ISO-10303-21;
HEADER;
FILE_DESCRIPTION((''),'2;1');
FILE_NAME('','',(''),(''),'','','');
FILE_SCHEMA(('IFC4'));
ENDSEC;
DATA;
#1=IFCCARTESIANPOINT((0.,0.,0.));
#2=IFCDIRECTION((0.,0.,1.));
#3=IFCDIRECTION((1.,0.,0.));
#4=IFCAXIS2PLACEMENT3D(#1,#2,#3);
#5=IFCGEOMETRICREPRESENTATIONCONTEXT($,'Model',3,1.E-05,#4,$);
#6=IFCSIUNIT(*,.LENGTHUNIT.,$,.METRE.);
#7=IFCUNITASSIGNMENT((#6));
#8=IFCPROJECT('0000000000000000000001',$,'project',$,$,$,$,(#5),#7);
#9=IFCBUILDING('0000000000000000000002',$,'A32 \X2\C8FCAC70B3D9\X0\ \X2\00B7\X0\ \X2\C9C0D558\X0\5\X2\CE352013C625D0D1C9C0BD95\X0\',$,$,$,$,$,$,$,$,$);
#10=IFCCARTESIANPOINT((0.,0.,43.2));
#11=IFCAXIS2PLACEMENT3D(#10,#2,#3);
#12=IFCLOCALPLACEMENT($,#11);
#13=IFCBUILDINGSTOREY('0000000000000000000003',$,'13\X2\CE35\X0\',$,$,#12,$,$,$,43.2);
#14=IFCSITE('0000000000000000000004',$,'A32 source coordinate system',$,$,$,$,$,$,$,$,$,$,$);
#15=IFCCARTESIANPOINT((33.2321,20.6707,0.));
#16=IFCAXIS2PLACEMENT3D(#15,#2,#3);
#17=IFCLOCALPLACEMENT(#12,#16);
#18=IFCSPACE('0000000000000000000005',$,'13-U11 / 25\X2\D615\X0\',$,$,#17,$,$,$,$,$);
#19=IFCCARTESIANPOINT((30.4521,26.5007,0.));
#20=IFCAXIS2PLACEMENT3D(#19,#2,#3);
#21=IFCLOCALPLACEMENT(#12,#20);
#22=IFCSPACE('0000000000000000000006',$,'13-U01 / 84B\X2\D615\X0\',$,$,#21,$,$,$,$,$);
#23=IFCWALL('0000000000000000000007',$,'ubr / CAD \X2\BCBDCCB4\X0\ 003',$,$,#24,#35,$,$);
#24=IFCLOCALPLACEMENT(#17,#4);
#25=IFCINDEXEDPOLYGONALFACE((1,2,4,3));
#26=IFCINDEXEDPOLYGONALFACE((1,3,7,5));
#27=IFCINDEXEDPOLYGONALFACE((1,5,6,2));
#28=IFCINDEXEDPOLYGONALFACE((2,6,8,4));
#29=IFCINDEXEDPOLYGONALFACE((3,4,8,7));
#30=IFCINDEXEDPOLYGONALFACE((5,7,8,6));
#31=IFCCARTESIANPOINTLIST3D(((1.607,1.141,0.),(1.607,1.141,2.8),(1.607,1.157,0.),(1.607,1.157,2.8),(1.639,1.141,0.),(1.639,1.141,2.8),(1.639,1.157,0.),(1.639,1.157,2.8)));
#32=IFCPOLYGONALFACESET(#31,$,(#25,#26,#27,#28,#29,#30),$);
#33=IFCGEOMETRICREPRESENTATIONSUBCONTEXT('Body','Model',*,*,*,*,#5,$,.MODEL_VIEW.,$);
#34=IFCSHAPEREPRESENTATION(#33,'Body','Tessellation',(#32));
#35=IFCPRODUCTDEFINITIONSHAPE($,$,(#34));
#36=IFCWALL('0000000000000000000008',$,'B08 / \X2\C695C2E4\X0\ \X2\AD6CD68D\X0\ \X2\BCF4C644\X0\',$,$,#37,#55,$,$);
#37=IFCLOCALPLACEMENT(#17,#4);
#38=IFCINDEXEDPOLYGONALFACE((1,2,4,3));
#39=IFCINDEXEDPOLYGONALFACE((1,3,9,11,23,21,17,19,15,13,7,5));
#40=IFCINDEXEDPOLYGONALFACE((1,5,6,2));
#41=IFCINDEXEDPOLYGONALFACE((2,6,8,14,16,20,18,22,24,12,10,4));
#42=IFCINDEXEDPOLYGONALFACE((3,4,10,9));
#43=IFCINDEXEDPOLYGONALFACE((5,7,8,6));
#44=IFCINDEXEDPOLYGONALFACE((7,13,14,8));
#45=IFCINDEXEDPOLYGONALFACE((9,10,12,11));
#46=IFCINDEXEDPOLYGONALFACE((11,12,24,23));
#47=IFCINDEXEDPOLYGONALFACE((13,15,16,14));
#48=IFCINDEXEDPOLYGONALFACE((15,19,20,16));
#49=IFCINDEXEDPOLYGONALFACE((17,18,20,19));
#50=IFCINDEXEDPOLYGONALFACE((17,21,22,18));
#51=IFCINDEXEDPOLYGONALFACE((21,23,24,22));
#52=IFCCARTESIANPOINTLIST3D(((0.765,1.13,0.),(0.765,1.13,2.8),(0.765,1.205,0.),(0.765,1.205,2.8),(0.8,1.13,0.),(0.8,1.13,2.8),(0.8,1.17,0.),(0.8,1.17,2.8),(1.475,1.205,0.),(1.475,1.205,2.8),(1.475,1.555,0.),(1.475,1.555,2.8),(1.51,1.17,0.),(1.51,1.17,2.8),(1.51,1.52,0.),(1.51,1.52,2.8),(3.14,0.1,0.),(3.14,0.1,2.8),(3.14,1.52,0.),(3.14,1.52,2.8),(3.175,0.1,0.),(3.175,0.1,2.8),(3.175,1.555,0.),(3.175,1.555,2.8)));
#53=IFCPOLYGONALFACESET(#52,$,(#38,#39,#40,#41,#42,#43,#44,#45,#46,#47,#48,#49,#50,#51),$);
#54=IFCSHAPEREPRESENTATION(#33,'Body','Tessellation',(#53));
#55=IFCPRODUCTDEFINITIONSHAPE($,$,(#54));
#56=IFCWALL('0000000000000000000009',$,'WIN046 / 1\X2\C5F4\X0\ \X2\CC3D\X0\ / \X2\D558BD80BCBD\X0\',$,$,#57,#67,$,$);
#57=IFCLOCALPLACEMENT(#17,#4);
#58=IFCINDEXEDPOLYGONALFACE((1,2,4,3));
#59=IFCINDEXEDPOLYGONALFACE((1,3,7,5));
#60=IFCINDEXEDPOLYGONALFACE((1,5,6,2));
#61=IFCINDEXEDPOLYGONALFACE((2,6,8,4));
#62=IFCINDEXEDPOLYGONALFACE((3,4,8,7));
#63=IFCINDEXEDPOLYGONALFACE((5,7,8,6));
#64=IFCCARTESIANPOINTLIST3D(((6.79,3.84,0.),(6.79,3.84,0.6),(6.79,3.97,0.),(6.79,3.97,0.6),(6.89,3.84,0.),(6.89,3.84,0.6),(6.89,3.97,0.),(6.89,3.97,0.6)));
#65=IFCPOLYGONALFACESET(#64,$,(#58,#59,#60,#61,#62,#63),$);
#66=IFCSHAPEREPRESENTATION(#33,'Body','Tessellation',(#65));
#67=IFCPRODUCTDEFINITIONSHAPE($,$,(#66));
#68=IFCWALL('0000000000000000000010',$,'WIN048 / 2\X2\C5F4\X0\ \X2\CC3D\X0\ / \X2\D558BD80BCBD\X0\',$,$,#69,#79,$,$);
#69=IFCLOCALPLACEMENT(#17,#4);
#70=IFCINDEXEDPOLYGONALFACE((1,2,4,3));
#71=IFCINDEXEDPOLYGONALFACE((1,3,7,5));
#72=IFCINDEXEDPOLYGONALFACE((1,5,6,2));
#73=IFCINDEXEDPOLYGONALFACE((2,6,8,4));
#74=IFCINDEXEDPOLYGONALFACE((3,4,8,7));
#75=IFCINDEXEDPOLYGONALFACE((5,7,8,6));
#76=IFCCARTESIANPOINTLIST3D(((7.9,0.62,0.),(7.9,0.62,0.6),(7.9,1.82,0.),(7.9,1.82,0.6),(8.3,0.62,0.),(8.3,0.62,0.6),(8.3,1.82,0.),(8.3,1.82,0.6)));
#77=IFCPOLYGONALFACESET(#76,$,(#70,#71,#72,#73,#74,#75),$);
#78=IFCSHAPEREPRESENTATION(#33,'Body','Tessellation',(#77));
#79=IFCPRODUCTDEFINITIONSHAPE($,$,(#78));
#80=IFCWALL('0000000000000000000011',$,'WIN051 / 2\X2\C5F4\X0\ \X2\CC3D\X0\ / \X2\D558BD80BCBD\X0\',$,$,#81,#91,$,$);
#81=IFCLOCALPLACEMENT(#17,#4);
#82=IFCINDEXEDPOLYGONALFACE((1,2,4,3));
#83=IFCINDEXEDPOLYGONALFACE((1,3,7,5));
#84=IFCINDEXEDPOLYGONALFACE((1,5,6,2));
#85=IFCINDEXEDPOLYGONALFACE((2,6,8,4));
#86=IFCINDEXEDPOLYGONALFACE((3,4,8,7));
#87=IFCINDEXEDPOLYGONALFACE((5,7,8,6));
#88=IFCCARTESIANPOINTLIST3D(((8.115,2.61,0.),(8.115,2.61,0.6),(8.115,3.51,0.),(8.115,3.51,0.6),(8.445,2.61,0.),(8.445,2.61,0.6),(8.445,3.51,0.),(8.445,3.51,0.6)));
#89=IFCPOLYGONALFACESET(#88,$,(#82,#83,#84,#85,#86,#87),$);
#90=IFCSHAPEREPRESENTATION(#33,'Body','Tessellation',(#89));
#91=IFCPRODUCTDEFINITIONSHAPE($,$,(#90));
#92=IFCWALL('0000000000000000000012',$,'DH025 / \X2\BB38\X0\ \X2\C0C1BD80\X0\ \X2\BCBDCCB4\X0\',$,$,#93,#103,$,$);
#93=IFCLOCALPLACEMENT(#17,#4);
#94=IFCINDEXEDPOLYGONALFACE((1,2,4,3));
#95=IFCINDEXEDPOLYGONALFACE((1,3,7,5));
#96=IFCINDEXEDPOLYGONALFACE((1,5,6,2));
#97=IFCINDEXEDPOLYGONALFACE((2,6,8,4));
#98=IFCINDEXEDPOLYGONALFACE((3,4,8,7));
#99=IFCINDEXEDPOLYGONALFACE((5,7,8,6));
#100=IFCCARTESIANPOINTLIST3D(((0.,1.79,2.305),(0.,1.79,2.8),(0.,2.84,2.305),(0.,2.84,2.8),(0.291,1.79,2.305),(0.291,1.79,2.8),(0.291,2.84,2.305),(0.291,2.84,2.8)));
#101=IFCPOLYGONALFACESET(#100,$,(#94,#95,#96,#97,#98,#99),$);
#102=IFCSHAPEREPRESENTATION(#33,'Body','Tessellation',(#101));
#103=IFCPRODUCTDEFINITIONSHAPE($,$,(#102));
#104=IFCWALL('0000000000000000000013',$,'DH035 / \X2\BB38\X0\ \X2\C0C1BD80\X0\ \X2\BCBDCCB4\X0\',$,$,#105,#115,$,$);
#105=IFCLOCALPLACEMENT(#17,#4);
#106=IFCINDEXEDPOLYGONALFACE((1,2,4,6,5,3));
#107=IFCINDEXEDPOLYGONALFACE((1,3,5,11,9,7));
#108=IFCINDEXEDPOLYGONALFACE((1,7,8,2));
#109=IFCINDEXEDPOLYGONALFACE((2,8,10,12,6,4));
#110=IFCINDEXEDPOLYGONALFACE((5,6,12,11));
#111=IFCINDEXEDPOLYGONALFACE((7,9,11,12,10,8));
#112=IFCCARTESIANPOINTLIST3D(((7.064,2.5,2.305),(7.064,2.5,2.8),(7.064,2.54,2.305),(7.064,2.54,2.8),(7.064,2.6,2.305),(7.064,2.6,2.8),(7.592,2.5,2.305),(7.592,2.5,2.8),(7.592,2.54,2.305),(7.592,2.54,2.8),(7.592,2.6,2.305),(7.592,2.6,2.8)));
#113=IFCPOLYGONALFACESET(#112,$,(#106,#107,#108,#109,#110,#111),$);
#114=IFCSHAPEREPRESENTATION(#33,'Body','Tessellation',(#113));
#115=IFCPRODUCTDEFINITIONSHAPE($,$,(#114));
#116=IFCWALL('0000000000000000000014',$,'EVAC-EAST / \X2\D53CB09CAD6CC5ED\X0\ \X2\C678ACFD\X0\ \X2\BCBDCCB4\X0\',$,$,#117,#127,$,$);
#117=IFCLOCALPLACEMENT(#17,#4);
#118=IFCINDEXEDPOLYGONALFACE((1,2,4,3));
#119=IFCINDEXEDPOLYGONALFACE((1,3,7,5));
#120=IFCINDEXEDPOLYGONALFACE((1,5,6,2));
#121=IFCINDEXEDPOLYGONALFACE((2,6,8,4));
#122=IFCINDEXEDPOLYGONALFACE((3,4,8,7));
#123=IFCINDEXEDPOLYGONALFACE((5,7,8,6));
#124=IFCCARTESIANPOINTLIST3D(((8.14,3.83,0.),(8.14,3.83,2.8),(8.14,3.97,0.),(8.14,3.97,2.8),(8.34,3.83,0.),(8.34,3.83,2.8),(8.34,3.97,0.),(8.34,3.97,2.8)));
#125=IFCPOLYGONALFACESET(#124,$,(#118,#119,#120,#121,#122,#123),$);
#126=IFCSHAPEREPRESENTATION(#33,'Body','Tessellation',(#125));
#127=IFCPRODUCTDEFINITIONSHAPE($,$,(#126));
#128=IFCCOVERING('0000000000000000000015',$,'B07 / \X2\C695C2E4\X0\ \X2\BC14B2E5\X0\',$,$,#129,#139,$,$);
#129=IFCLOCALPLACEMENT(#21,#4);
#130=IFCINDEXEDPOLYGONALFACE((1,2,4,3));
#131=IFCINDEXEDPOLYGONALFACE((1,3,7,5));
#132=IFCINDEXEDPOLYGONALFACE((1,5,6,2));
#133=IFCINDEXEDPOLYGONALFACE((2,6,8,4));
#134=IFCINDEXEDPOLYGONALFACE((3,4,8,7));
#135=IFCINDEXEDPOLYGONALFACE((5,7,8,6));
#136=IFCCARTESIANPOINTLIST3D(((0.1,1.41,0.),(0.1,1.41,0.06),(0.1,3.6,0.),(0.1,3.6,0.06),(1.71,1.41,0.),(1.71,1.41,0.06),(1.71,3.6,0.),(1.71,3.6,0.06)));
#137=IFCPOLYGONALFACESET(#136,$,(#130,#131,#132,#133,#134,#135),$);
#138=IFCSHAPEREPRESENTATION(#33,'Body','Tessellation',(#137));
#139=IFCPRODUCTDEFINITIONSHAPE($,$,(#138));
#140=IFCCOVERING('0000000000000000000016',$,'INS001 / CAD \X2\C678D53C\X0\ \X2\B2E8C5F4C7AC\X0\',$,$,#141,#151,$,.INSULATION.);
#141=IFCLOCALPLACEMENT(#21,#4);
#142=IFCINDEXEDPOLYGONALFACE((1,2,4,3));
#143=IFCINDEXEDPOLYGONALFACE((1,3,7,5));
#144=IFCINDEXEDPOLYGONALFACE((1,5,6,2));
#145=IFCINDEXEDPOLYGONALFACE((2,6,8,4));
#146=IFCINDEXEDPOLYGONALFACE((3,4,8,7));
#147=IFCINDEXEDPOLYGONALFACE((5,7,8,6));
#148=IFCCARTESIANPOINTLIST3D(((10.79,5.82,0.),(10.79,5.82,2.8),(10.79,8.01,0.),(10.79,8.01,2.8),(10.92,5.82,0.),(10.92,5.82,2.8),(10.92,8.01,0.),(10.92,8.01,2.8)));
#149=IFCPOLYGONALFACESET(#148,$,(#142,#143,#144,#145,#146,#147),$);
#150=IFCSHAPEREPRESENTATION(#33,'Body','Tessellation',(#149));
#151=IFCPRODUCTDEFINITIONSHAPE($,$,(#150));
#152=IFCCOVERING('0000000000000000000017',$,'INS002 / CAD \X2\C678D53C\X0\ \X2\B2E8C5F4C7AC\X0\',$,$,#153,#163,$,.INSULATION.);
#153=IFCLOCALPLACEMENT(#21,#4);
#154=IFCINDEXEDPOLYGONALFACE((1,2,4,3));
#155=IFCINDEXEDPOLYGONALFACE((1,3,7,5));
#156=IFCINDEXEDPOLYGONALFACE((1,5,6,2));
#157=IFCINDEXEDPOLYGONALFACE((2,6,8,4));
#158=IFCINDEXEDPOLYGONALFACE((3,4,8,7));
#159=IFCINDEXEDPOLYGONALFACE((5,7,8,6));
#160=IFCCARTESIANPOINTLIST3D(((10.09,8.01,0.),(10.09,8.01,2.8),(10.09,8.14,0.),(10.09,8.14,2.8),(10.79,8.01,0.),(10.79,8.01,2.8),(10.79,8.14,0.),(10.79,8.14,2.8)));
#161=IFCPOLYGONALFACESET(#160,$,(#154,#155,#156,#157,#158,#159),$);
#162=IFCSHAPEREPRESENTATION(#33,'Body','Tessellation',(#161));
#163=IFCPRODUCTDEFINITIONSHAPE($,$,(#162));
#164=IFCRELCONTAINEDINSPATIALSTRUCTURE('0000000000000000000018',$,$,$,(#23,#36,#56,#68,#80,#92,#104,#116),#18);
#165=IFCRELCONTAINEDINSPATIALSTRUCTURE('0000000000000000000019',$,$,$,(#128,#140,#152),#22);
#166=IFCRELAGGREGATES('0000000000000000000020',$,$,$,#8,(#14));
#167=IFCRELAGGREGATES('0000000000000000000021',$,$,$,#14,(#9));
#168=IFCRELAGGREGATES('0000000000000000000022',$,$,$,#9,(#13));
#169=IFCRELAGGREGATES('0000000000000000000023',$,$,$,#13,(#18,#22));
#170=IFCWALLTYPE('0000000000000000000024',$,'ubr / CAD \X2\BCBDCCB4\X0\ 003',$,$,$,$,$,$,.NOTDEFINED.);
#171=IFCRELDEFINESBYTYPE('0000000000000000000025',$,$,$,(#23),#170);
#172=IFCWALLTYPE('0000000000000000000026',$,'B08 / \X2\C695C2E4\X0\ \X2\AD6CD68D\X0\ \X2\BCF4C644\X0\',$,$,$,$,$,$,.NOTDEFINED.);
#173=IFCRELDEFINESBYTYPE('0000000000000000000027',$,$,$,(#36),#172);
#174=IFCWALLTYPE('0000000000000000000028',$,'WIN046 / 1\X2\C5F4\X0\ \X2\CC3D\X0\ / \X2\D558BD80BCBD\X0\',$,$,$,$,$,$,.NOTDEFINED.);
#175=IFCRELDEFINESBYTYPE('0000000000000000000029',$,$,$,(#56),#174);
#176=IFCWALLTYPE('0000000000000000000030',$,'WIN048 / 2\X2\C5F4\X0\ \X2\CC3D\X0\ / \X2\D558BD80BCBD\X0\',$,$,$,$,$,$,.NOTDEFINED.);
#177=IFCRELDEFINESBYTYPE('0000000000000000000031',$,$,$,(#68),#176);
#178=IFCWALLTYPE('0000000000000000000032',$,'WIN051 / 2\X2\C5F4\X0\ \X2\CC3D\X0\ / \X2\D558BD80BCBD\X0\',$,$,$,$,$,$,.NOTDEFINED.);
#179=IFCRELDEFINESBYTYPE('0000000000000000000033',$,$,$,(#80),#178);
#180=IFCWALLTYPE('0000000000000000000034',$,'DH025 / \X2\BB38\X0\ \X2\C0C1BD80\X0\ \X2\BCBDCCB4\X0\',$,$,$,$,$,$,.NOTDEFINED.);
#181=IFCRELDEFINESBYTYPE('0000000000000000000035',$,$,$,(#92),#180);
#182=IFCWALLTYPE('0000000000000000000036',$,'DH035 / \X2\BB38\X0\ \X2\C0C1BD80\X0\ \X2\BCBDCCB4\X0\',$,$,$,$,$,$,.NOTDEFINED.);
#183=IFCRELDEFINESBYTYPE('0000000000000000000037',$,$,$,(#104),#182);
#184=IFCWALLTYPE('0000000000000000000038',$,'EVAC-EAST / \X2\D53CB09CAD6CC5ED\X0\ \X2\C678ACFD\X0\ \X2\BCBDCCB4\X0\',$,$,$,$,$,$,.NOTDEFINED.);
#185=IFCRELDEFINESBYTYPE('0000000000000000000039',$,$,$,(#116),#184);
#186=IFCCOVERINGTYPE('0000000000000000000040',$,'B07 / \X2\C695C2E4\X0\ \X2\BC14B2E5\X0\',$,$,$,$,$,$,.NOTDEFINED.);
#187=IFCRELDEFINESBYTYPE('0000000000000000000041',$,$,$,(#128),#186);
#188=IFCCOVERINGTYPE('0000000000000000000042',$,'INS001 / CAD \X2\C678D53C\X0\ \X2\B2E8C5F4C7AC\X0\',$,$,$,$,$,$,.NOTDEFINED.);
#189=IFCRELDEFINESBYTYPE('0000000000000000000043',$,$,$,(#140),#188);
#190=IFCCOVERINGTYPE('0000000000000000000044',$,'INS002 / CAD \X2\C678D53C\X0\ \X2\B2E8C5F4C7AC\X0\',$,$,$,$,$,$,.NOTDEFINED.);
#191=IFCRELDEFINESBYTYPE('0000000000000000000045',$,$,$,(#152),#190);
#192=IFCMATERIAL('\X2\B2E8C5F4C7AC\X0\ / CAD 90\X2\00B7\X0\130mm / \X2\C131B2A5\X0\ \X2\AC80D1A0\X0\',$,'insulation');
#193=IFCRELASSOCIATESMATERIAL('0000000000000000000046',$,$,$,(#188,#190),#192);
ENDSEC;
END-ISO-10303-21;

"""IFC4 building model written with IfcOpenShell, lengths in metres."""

from ifc_helpers import new_model, si_unit, frame, origin, origin_with_axes, place, context, subcontext, project, spatial, polyline, outline, extrude, source, transform, mapped, material, type_object, type_shapes, element, save


model = new_model("IFC4")

# Units and contexts
model_context = context("Model", 3, precision=1e-05, world=origin_with_axes())
body_context = subcontext(model_context, "Body", "Model", "MODEL_VIEW")
ifc_project = project(units=[si_unit("LENGTHUNIT", "METRE")], contexts=[model_context])

# Site, building, storey, space
site = spatial("IfcSite", under=ifc_project, Name="A32 source coordinate system")
building = spatial("IfcBuilding", under=site, Name="A32 주거동 · 지하5층–옥탑지붕")
storey_placement = place(None, frame((0.0, 0.0, 43.2), z_axis=(0.0, 0.0, 1.0), x_axis=(1.0, 0.0, 0.0)))
storey = spatial("IfcBuildingStorey", under=building, at=storey_placement, Name="13층", Elevation=43.2)
space_1_placement = place(storey_placement, frame((33.2321, 20.6707, 0.0), z_axis=(0.0, 0.0, 1.0), x_axis=(1.0, 0.0, 0.0)))
space_1 = spatial("IfcSpace", under=storey, at=space_1_placement, Name="13-U11 / 25형")

# Walls
wall_type_1 = type_object("IfcWallType", Name="ubr / CAD 벽체 003", PredefinedType="NOTDEFINED")
shared_shape_1 = source(origin(), body_context, "Body", "SweptSolid", [
    extrude(outline(polyline([(1.639, 1.157), (1.639, 1.141), (1.607, 1.141), (1.607, 1.157), (1.639, 1.157)])), origin(), (0.0, 0.0, 1.0), 2.8),
])
type_shapes(wall_type_1, [shared_shape_1])
wall_1_placement = place(space_1_placement, origin_with_axes())
element("IfcWall", 1, at=wall_1_placement, inside=space_1, type_object=wall_type_1, Name="ubr / CAD 벽체 003", context=body_context, shape_type="MappedRepresentation", body=[
    mapped(shared_shape_1, transform((0.0, 0.0, 0.0), scale=1.0)),
])
wall_type_2 = type_object("IfcWallType", Name="B08 / 욕실 구획 보완", PredefinedType="NOTDEFINED")
shared_shape_2 = source(origin(), body_context, "Body", "SweptSolid", [
    extrude(outline(polyline([(0.765, 1.205), (1.475, 1.205), (1.475, 1.555), (3.175, 1.555), (3.175, 0.1), (3.14, 0.1), (3.14, 1.52), (1.51, 1.52), (1.51, 1.17), (0.8, 1.17), (0.8, 1.13), (0.765, 1.13), (0.765, 1.205)])), origin(), (0.0, 0.0, 1.0), 2.8),
])
type_shapes(wall_type_2, [shared_shape_2])
wall_2_placement = place(space_1_placement, origin_with_axes())
element("IfcWall", 2, at=wall_2_placement, inside=space_1, type_object=wall_type_2, Name="B08 / 욕실 구획 보완", context=body_context, shape_type="MappedRepresentation", body=[
    mapped(shared_shape_2, transform((0.0, 0.0, 0.0), scale=1.0)),
])
wall_type_3 = type_object("IfcWallType", Name="WIN046 / 1열 창 / 하부벽", PredefinedType="NOTDEFINED")
shared_shape_3 = source(origin(), body_context, "Body", "SweptSolid", [
    extrude(outline(polyline([(6.89, 3.84), (6.79, 3.84), (6.79, 3.97), (6.89, 3.97), (6.89, 3.84)])), origin(), (0.0, 0.0, 1.0), 0.6),
])
type_shapes(wall_type_3, [shared_shape_3])
wall_3_placement = place(space_1_placement, origin_with_axes())
element("IfcWall", 3, at=wall_3_placement, inside=space_1, type_object=wall_type_3, Name="WIN046 / 1열 창 / 하부벽", context=body_context, shape_type="MappedRepresentation", body=[
    mapped(shared_shape_3, transform((0.0, 0.0, 0.0), scale=1.0)),
])
wall_type_4 = type_object("IfcWallType", Name="WIN048 / 2열 창 / 하부벽", PredefinedType="NOTDEFINED")
shared_shape_4 = source(origin(), body_context, "Body", "SweptSolid", [
    extrude(outline(polyline([(8.3, 0.62), (7.9, 0.62), (7.9, 1.82), (8.3, 1.82), (8.3, 0.62)])), origin(), (0.0, 0.0, 1.0), 0.6),
])
type_shapes(wall_type_4, [shared_shape_4])
wall_4_placement = place(space_1_placement, origin_with_axes())
element("IfcWall", 4, at=wall_4_placement, inside=space_1, type_object=wall_type_4, Name="WIN048 / 2열 창 / 하부벽", context=body_context, shape_type="MappedRepresentation", body=[
    mapped(shared_shape_4, transform((0.0, 0.0, 0.0), scale=1.0)),
])
wall_type_5 = type_object("IfcWallType", Name="WIN051 / 2열 창 / 하부벽", PredefinedType="NOTDEFINED")
shared_shape_5 = source(origin(), body_context, "Body", "SweptSolid", [
    extrude(outline(polyline([(8.445, 2.61), (8.115, 2.61), (8.115, 3.51), (8.445, 3.51), (8.445, 2.61)])), origin(), (0.0, 0.0, 1.0), 0.6),
])
type_shapes(wall_type_5, [shared_shape_5])
wall_5_placement = place(space_1_placement, origin_with_axes())
element("IfcWall", 5, at=wall_5_placement, inside=space_1, type_object=wall_type_5, Name="WIN051 / 2열 창 / 하부벽", context=body_context, shape_type="MappedRepresentation", body=[
    mapped(shared_shape_5, transform((0.0, 0.0, 0.0), scale=1.0)),
])
wall_type_6 = type_object("IfcWallType", Name="DH025 / 문 상부 벽체", PredefinedType="NOTDEFINED")
shared_shape_6 = source(origin(), body_context, "Body", "SweptSolid", [
    extrude(outline(polyline([(0.0, 1.79), (0.0, 2.84), (0.291, 2.84), (0.291, 1.79), (0.0, 1.79)])), frame((0.0, 0.0, 2.305)), (0.0, 0.0, 1.0), 0.495),
])
type_shapes(wall_type_6, [shared_shape_6])
wall_6_placement = place(space_1_placement, origin_with_axes())
element("IfcWall", 6, at=wall_6_placement, inside=space_1, type_object=wall_type_6, Name="DH025 / 문 상부 벽체", context=body_context, shape_type="MappedRepresentation", body=[
    mapped(shared_shape_6, transform((0.0, 0.0, 0.0), scale=1.0)),
])
wall_type_7 = type_object("IfcWallType", Name="DH035 / 문 상부 벽체", PredefinedType="NOTDEFINED")
shared_shape_7 = source(origin(), body_context, "Body", "SweptSolid", [
    extrude(outline(polyline([(7.592, 2.6), (7.592, 2.54), (7.592, 2.5), (7.064, 2.5), (7.064, 2.54), (7.064, 2.6), (7.592, 2.6)])), frame((0.0, 0.0, 2.305)), (0.0, 0.0, 1.0), 0.495),
])
type_shapes(wall_type_7, [shared_shape_7])
wall_7_placement = place(space_1_placement, origin_with_axes())
element("IfcWall", 7, at=wall_7_placement, inside=space_1, type_object=wall_type_7, Name="DH035 / 문 상부 벽체", context=body_context, shape_type="MappedRepresentation", body=[
    mapped(shared_shape_7, transform((0.0, 0.0, 0.0), scale=1.0)),
])
wall_type_8 = type_object("IfcWallType", Name="EVAC-EAST / 피난구역 외곽 벽체", PredefinedType="NOTDEFINED")
shared_shape_8 = source(origin(), body_context, "Body", "SweptSolid", [
    extrude(outline(polyline([(8.34, 3.83), (8.14, 3.83), (8.14, 3.97), (8.34, 3.97), (8.34, 3.83)])), origin(), (0.0, 0.0, 1.0), 2.8),
])
type_shapes(wall_type_8, [shared_shape_8])
wall_8_placement = place(space_1_placement, origin_with_axes())
element("IfcWall", 8, at=wall_8_placement, inside=space_1, type_object=wall_type_8, Name="EVAC-EAST / 피난구역 외곽 벽체", context=body_context, shape_type="MappedRepresentation", body=[
    mapped(shared_shape_8, transform((0.0, 0.0, 0.0), scale=1.0)),
])

# Shared definitions
space_2_placement = place(storey_placement, frame((30.4521, 26.5007, 0.0), z_axis=(0.0, 0.0, 1.0), x_axis=(1.0, 0.0, 0.0)))
space_2 = spatial("IfcSpace", under=storey, at=space_2_placement, Name="13-U01 / 84B형")

# Coverings
covering_type_1 = type_object("IfcCoveringType", Name="B07 / 욕실 바닥", PredefinedType="NOTDEFINED")
shared_shape_9 = source(origin(), body_context, "Body", "SweptSolid", [
    extrude(outline(polyline([(1.71, 1.41), (0.1, 1.41), (0.1, 3.6), (1.71, 3.6), (1.71, 1.41)])), origin(), (0.0, 0.0, 1.0), 0.06),
])
type_shapes(covering_type_1, [shared_shape_9])
covering_1_placement = place(space_2_placement, origin_with_axes())
element("IfcCovering", 9, at=covering_1_placement, inside=space_2, type_object=covering_type_1, Name="B07 / 욕실 바닥", context=body_context, shape_type="MappedRepresentation", body=[
    mapped(shared_shape_9, transform((0.0, 0.0, 0.0), scale=1.0)),
])
ifc_material = material(Name="단열재 / CAD 90·130mm / 성능 검토", Category="insulation")
covering_type_2 = type_object("IfcCoveringType", Name="INS001 / CAD 외피 단열재", PredefinedType="NOTDEFINED", material=ifc_material)
shared_shape_10 = source(origin(), body_context, "Body", "SweptSolid", [
    extrude(outline(polyline([(10.79, 5.82), (10.79, 8.01), (10.92, 8.01), (10.92, 5.82), (10.79, 5.82)])), origin(), (0.0, 0.0, 1.0), 2.8),
])
type_shapes(covering_type_2, [shared_shape_10])
covering_2_placement = place(space_2_placement, origin_with_axes())
element("IfcCovering", 10, at=covering_2_placement, inside=space_2, type_object=covering_type_2, Name="INS001 / CAD 외피 단열재", PredefinedType="INSULATION", context=body_context, shape_type="MappedRepresentation", body=[
    mapped(shared_shape_10, transform((0.0, 0.0, 0.0), scale=1.0)),
])
covering_type_3 = type_object("IfcCoveringType", Name="INS002 / CAD 외피 단열재", PredefinedType="NOTDEFINED", material=ifc_material)
shared_shape_11 = source(origin(), body_context, "Body", "SweptSolid", [
    extrude(outline(polyline([(10.79, 8.01), (10.09, 8.01), (10.09, 8.14), (10.79, 8.14), (10.79, 8.01)])), origin(), (0.0, 0.0, 1.0), 2.8),
])
type_shapes(covering_type_3, [shared_shape_11])
covering_3_placement = place(space_2_placement, origin_with_axes())
element("IfcCovering", 11, at=covering_3_placement, inside=space_2, type_object=covering_type_3, Name="INS002 / CAD 외피 단열재", PredefinedType="INSULATION", context=body_context, shape_type="MappedRepresentation", body=[
    mapped(shared_shape_11, transform((0.0, 0.0, 0.0), scale=1.0)),
])

save(model, "model.ifc")
